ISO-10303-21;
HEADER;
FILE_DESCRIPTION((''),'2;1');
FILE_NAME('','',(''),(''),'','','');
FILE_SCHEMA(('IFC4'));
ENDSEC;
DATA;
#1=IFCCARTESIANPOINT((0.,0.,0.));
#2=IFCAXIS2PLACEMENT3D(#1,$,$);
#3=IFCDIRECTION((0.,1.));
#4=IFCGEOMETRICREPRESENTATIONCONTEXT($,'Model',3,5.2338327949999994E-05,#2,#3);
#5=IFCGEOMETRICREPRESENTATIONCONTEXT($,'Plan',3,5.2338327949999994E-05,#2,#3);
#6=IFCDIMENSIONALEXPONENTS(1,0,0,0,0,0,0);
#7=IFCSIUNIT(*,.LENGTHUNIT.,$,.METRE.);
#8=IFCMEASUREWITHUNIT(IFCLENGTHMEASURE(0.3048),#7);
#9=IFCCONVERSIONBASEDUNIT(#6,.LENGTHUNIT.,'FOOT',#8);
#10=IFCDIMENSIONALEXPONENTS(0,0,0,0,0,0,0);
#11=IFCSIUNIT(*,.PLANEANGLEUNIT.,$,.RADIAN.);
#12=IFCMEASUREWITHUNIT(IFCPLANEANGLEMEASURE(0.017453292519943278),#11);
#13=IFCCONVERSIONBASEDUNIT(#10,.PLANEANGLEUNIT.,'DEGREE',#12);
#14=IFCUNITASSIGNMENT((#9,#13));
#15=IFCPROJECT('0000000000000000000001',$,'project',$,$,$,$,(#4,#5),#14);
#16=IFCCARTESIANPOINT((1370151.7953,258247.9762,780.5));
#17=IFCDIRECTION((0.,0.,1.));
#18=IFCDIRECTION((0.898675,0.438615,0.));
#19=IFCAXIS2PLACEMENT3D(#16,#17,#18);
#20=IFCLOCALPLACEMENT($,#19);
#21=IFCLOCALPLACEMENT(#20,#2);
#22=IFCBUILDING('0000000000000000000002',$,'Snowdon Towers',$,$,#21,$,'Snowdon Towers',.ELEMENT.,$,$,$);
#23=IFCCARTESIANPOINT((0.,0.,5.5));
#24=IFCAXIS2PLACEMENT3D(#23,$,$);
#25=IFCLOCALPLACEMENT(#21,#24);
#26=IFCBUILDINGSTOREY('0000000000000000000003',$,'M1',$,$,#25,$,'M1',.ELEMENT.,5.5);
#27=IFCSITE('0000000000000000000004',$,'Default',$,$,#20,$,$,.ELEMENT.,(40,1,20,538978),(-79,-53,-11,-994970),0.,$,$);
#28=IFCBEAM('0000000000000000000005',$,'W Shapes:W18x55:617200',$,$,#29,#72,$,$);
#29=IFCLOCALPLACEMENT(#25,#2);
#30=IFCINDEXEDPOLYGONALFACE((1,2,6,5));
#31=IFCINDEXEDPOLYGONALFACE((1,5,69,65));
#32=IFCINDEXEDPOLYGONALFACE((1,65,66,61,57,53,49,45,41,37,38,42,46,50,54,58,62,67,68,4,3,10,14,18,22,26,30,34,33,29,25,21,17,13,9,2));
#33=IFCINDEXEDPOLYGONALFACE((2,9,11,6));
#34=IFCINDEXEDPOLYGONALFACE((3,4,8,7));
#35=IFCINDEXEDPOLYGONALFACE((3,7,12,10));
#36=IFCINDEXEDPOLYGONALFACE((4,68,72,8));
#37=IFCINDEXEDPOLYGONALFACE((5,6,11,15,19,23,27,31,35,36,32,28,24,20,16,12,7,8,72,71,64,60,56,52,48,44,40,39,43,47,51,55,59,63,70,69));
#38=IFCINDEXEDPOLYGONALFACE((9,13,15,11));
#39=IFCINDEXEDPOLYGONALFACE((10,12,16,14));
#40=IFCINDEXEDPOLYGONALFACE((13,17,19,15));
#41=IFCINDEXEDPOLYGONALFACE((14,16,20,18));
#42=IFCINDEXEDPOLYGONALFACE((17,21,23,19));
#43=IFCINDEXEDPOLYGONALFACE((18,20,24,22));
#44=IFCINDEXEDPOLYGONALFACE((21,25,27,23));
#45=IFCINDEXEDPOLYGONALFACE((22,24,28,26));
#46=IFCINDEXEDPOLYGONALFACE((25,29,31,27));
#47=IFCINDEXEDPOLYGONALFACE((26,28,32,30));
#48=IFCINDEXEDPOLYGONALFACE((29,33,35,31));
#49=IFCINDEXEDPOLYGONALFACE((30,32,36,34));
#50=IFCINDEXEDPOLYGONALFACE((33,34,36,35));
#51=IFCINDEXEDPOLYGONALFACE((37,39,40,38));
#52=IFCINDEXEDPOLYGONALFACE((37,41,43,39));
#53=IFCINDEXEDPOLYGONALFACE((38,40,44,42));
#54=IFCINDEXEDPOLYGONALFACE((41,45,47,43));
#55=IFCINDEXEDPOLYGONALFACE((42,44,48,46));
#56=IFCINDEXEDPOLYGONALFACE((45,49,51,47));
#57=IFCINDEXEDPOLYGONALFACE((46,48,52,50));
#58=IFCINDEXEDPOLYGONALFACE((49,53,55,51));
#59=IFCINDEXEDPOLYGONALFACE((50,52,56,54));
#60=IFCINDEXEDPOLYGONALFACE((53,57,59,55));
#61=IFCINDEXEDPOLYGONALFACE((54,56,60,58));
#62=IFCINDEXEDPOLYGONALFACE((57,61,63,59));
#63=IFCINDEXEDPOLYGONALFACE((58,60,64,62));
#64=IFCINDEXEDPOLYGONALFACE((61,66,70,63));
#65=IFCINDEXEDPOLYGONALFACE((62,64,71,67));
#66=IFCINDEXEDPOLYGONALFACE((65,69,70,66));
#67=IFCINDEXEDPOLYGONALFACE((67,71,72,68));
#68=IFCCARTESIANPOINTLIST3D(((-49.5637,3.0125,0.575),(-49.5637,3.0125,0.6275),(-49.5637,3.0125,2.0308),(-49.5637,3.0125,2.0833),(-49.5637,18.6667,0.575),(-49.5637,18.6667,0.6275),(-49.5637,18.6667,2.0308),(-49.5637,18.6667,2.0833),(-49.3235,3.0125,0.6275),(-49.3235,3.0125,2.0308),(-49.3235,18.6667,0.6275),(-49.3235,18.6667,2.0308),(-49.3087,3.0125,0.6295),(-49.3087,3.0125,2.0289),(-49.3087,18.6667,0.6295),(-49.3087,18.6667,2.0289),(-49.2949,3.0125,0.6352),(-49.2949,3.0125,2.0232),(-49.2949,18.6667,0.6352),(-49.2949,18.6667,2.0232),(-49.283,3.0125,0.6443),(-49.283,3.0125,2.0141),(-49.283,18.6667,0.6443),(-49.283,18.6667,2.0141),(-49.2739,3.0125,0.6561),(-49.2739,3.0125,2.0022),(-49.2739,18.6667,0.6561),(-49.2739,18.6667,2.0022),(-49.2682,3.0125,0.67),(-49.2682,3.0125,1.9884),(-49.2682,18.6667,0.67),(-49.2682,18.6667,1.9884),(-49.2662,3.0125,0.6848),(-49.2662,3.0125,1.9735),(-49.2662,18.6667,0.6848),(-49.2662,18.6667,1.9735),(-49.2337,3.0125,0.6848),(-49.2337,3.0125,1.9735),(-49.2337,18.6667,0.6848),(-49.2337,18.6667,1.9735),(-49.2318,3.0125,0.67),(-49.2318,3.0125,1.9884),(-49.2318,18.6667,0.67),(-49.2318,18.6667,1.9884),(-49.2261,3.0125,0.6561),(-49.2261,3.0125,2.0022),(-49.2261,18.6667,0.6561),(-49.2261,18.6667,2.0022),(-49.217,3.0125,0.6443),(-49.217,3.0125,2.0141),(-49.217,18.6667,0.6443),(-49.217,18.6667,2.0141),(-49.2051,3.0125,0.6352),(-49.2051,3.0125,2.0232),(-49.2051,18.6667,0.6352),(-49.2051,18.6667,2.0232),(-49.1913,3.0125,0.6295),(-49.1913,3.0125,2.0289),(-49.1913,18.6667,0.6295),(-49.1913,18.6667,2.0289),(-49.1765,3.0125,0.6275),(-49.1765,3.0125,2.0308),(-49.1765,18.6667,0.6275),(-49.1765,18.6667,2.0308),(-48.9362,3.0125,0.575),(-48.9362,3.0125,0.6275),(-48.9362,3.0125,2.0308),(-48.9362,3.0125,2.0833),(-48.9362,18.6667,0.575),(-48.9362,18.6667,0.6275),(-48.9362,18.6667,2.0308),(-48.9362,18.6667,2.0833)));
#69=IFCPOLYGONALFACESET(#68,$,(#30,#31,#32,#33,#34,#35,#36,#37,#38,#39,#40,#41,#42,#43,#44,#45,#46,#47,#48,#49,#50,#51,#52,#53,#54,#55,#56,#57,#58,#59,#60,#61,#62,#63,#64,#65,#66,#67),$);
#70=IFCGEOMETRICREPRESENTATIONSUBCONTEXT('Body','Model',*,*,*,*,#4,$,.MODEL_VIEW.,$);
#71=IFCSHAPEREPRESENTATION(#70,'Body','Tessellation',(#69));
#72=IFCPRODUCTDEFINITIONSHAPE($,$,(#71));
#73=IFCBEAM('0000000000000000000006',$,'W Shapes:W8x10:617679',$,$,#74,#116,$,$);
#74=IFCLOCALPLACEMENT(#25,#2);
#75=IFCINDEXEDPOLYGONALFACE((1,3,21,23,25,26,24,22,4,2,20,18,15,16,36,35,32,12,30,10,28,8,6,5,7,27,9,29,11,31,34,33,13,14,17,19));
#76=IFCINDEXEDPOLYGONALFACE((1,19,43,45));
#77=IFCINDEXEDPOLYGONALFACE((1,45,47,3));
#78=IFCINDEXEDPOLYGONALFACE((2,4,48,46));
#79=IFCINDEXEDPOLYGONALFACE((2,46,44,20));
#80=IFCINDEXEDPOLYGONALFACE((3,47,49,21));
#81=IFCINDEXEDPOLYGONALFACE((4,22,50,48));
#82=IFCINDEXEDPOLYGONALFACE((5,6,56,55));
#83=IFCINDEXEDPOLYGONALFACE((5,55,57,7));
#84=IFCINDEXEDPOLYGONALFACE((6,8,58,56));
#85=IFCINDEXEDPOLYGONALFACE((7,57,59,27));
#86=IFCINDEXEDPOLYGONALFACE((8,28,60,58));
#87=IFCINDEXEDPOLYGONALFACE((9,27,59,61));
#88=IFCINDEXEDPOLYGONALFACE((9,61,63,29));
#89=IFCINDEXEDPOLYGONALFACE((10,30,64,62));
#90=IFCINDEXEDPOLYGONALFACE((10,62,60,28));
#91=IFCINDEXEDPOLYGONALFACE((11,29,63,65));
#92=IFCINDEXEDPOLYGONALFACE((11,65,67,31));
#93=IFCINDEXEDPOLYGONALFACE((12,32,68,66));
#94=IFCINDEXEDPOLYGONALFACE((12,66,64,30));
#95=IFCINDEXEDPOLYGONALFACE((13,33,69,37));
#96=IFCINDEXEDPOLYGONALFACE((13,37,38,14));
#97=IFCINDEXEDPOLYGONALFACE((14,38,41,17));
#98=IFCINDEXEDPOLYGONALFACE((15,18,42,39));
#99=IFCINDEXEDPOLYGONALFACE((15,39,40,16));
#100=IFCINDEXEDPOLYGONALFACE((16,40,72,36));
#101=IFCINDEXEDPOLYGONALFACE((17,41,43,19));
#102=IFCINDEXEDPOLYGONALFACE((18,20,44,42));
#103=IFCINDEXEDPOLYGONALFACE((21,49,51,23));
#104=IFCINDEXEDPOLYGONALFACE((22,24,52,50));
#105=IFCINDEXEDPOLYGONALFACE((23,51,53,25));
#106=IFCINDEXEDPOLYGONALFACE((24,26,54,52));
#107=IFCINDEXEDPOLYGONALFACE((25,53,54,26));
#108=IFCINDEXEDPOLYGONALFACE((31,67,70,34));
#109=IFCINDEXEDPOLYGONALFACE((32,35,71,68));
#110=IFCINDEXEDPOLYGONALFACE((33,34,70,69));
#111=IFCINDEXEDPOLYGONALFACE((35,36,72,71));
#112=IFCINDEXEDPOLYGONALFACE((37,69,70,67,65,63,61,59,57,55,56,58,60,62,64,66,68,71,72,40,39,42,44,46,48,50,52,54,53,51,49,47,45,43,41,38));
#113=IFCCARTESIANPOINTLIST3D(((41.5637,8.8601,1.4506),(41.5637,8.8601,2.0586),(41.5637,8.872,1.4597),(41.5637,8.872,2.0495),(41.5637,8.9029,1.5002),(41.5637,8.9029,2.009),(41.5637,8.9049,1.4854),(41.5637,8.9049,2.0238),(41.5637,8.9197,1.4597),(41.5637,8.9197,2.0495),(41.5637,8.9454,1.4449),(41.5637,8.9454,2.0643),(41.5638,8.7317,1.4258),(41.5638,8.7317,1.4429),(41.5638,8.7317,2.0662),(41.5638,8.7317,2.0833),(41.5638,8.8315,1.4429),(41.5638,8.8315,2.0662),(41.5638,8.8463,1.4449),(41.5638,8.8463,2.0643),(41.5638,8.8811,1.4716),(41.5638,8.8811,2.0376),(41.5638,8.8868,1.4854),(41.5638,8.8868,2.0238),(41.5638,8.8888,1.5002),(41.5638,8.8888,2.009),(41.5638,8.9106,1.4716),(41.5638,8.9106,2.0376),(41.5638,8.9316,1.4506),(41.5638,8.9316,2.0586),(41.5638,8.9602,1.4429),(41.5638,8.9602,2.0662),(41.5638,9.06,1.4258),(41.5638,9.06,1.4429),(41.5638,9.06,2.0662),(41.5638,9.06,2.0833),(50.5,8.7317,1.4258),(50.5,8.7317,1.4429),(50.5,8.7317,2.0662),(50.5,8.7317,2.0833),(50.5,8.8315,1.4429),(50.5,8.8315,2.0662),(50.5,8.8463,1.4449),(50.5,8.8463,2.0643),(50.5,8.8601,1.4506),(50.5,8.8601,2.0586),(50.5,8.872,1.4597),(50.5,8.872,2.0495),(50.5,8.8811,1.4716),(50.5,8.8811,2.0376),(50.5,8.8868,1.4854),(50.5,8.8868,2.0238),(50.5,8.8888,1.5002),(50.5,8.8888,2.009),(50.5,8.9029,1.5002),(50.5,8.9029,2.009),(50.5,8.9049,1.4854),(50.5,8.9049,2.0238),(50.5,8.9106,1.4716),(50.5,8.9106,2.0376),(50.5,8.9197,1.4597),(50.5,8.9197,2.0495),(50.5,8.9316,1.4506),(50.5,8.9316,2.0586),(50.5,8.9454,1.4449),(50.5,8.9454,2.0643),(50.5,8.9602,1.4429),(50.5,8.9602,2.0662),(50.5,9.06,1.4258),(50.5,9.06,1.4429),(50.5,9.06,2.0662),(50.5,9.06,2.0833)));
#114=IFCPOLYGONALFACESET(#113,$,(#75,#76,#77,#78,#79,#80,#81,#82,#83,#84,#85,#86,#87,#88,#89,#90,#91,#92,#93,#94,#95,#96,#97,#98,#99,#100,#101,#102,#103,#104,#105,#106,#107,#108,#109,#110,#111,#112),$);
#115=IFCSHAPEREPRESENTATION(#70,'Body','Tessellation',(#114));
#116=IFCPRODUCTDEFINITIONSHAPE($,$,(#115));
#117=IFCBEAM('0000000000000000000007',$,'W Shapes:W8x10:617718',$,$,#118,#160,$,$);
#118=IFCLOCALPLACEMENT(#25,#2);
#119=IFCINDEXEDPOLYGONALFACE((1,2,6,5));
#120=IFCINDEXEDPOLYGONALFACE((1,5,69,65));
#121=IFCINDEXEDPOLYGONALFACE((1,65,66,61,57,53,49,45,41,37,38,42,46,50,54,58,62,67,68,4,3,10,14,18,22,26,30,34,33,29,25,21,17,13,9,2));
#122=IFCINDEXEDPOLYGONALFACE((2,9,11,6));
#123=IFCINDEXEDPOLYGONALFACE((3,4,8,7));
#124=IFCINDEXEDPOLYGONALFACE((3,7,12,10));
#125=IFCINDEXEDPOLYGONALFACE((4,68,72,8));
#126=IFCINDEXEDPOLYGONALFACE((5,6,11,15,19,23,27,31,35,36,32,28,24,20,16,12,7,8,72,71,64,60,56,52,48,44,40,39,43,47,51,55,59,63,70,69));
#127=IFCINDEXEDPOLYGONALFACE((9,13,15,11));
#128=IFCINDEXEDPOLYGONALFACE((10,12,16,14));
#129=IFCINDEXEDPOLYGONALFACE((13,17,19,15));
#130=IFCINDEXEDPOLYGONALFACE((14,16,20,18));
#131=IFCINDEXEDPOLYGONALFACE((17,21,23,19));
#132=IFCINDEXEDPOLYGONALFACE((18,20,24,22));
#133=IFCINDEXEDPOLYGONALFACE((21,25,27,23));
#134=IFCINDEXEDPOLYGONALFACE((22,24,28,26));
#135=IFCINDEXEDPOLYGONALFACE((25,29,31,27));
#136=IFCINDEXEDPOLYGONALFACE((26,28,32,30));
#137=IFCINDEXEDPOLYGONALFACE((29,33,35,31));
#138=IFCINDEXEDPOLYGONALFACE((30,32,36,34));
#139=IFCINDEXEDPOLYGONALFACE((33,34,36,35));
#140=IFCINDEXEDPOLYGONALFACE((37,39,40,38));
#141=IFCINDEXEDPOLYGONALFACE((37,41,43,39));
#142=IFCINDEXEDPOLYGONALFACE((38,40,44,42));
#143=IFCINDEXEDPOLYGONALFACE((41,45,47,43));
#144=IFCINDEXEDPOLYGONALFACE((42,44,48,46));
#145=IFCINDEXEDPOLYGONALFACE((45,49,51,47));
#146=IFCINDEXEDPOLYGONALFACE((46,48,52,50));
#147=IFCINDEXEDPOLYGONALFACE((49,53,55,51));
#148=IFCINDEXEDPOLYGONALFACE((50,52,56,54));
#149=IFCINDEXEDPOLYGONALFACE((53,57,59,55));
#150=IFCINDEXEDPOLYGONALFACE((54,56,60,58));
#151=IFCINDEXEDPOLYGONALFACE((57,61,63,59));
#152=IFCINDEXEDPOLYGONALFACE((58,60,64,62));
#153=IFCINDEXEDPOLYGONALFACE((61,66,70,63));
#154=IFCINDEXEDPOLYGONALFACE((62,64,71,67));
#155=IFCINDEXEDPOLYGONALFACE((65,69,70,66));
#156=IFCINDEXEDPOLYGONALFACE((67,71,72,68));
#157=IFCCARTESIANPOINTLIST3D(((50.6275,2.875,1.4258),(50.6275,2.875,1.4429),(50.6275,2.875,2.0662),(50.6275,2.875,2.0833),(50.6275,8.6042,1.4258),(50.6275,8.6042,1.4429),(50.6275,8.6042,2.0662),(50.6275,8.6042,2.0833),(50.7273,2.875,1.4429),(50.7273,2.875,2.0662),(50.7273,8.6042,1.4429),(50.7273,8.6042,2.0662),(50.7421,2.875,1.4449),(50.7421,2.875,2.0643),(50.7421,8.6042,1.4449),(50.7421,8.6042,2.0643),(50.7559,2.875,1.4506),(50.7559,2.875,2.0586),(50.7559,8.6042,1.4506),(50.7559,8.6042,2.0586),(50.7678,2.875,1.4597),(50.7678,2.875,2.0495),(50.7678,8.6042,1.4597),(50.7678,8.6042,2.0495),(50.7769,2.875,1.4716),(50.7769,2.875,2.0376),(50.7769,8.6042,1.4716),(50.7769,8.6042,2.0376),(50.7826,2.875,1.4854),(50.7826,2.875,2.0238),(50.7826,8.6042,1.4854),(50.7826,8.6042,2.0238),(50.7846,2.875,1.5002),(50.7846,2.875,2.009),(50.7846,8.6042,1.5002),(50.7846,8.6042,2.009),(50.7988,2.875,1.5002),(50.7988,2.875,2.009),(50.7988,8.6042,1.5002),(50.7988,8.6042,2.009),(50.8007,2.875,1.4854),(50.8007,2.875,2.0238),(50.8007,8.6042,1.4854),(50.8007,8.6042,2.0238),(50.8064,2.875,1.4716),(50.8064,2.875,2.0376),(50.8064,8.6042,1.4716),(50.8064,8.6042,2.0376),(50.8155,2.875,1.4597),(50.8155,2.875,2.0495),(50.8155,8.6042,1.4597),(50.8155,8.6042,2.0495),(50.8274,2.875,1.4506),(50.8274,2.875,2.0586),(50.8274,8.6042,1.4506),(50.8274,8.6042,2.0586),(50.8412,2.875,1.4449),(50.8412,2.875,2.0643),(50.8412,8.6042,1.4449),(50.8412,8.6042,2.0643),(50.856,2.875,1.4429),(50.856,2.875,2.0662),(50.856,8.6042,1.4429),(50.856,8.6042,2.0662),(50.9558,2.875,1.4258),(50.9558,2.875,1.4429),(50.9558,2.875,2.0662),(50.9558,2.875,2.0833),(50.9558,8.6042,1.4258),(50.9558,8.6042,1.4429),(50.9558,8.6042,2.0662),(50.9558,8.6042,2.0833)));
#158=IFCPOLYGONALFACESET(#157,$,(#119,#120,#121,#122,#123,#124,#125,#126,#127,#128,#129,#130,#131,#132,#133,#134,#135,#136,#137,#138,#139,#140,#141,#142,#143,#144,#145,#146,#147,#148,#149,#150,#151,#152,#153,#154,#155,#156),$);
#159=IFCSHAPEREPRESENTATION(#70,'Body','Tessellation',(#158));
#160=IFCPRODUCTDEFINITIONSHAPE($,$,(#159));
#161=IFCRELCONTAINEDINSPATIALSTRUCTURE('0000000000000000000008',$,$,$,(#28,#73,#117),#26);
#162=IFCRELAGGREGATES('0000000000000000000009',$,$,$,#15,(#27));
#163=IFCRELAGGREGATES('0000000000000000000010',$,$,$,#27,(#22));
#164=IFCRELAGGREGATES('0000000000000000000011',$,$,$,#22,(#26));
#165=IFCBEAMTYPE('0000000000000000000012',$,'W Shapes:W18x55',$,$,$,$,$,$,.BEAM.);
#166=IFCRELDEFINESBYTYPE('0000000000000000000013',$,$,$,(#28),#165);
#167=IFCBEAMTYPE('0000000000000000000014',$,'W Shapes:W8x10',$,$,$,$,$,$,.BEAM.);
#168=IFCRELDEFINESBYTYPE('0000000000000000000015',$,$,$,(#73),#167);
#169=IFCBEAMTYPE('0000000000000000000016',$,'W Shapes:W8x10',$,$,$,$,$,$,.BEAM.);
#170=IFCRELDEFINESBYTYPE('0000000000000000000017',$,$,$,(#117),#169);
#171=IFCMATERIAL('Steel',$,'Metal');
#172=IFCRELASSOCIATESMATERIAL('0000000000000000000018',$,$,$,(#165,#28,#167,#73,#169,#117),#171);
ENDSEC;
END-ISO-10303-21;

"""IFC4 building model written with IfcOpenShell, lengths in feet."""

from ifc_helpers import new_model, entity, si_unit, converted_unit, direction, frame, origin, place, context, subcontext, project, spatial, line, arc, indexed_curve, outline, extrude, source, transform, mapped, material, type_object, type_shapes, element, save


model = new_model("IFC4")

# Units and contexts
model_context = context("Model", 3, precision=5.2338327949999994e-05, world=origin(), true_north=direction((0.0, 1.0)))
plan_context = context("Plan", 3, precision=5.2338327949999994e-05, world=origin(), true_north=direction((0.0, 1.0)))
body_context = subcontext(model_context, "Body", "Model", "MODEL_VIEW")
ifc_project = project(units=[converted_unit("LENGTHUNIT", "FOOT", entity("IfcLengthMeasure", 0.3048), si_unit("LENGTHUNIT", "METRE"), dimensions=[1, 0, 0, 0, 0, 0, 0]), converted_unit("PLANEANGLEUNIT", "DEGREE", entity("IfcPlaneAngleMeasure", 0.017453292519943278), si_unit("PLANEANGLEUNIT", "RADIAN"), dimensions=[0, 0, 0, 0, 0, 0, 0])], contexts=[model_context, plan_context])

# Site, building, storey
site_placement = place(None, frame((1370151.7953, 258247.9762, 780.5), z_axis=(0.0, 0.0, 1.0), x_axis=(0.898675, 0.438615, 0.0)))
site = spatial("IfcSite", under=ifc_project, at=site_placement, Name="Default", CompositionType="ELEMENT", RefLatitude=(40, 1, 20, 538978), RefLongitude=(-79, -53, -11, -994970), RefElevation=0.0)
building_placement = place(site_placement, origin())
building = spatial("IfcBuilding", under=site, at=building_placement, Name="Snowdon Towers", LongName="Snowdon Towers", CompositionType="ELEMENT")
storey_placement = place(building_placement, frame((0.0, 0.0, 5.5)))
storey = spatial("IfcBuildingStorey", under=building, at=storey_placement, Name="M1", LongName="M1", CompositionType="ELEMENT", Elevation=5.5)

# Beams
ifc_material_1 = material(Name="Steel", Category="Metal")
beam_type_1 = type_object("IfcBeamType", Name="W Shapes:W18x55", PredefinedType="BEAM", material=ifc_material_1)
shared_shape_1 = source(origin(), body_context, "Body", "SweptSolid", [
    extrude(outline(indexed_curve([(-0.7542, -0.3138), (-0.7017, -0.3138), (-0.7017, -0.0735), (-0.6849, -0.033), (-0.6444, -0.0162), (0.6444, -0.0162), (0.6849, -0.033), (0.7017, -0.0735), (0.7017, -0.3138), (0.7542, -0.3138), (0.7542, 0.3138), (0.7017, 0.3138), (0.7017, 0.0735), (0.6849, 0.033), (0.6444, 0.0163), (-0.6444, 0.0163), (-0.6849, 0.033), (-0.7017, 0.0735), (-0.7017, 0.3137), (-0.7542, 0.3137)], segments=[line(1, 2, 3), arc(3, 4, 5), line(5, 6), arc(6, 7, 8), line(8, 9, 10, 11, 12, 13), arc(13, 14, 15), line(15, 16), arc(16, 17, 18), line(18, 19, 20, 1)], self_intersect=False)), frame((-7.8417, 0.0, 0.0), z_axis=(1.0, 0.0, 0.0), x_axis=(0.0, 0.0, -1.0)), (0.0, 0.0, 1.0), 15.6542),
])
type_shapes(beam_type_1, [shared_shape_1])
beam_1_placement = place(storey_placement, frame((-49.25, 10.8542, 1.3292), z_axis=(0.0, 0.0, 1.0), x_axis=(0.0, 1.0, 0.0)))
element("IfcBeam", 1, at=beam_1_placement, inside=storey, type_object=beam_type_1, material=ifc_material_1, Name="W Shapes:W18x55:617200", context=body_context, shape_type="MappedRepresentation", body=[
    mapped(shared_shape_1, transform((0.0, 0.0, 0.0), scale=1.0)),
])
beam_type_2 = type_object("IfcBeamType", Name="W Shapes:W8x10", PredefinedType="BEAM", material=ifc_material_1)
shared_shape_2 = source(origin(), body_context, "Body", "SweptSolid", [
    extrude(outline(indexed_curve([(-0.3287, -0.1642), (-0.3117, -0.1642), (-0.3117, -0.0644), (-0.2949, -0.0239), (-0.2544, -0.0071), (0.2544, -0.0071), (0.2949, -0.0239), (0.3117, -0.0644), (0.3117, -0.1642), (0.3288, -0.1642), (0.3288, 0.1642), (0.3117, 0.1642), (0.3117, 0.0644), (0.2949, 0.0239), (0.2544, 0.0071), (-0.2544, 0.0071), (-0.2949, 0.0239), (-0.3117, 0.0644), (-0.3117, 0.1642), (-0.3287, 0.1642)], segments=[line(1, 2, 3), arc(3, 4, 5), line(5, 6), arc(6, 7, 8), line(8, 9, 10, 11, 12, 13), arc(13, 14, 15), line(15, 16), arc(16, 17, 18), line(18, 19, 20, 1)], self_intersect=False)), frame((-4.4792, 0.0, 0.0), z_axis=(1.0, 0.0, 0.0), x_axis=(0.0, 0.0, -1.0)), (0.0, 0.0, 1.0), 8.9362),
])
type_shapes(beam_type_2, [shared_shape_2])
beam_2_placement = place(storey_placement, frame((46.0208, 8.8958, 1.7546), z_axis=(0.0, 0.0, 1.0), x_axis=(-1.0, 0.0, 0.0)))
element("IfcBeam", 2, at=beam_2_placement, inside=storey, type_object=beam_type_2, material=ifc_material_1, Name="W Shapes:W8x10:617679", context=body_context, shape_type="MappedRepresentation", body=[
    mapped(shared_shape_2, transform((0.0, 0.0, 0.0), scale=1.0)),
])
beam_type_3 = type_object("IfcBeamType", Name="W Shapes:W8x10", PredefinedType="BEAM", material=ifc_material_1)
shared_shape_3 = source(origin(), body_context, "Body", "SweptSolid", [
    extrude(outline(indexed_curve([(-0.3287, -0.1642), (-0.3117, -0.1642), (-0.3117, -0.0644), (-0.2949, -0.0239), (-0.2544, -0.0071), (0.2544, -0.0071), (0.2949, -0.0239), (0.3117, -0.0644), (0.3117, -0.1642), (0.3288, -0.1642), (0.3288, 0.1642), (0.3117, 0.1642), (0.3117, 0.0644), (0.2949, 0.0239), (0.2544, 0.0071), (-0.2544, 0.0071), (-0.2949, 0.0239), (-0.3117, 0.0644), (-0.3117, 0.1642), (-0.3287, 0.1642)], segments=[line(1, 2, 3), arc(3, 4, 5), line(5, 6), arc(6, 7, 8), line(8, 9, 10, 11, 12, 13), arc(13, 14, 15), line(15, 16), arc(16, 17, 18), line(18, 19, 20, 1)], self_intersect=False)), frame((-2.9167, 0.0, 0.0), z_axis=(1.0, 0.0, 0.0), x_axis=(0.0, 0.0, -1.0)), (0.0, 0.0, 1.0), 5.7292),
])
type_shapes(beam_type_3, [shared_shape_3])
beam_3_placement = place(storey_placement, frame((50.7917, 5.6875, 1.7546), z_axis=(0.0, 0.0, 1.0), x_axis=(0.0, -1.0, 0.0)))
element("IfcBeam", 3, at=beam_3_placement, inside=storey, type_object=beam_type_3, material=ifc_material_1, Name="W Shapes:W8x10:617718", context=body_context, shape_type="MappedRepresentation", body=[
    mapped(shared_shape_3, transform((0.0, 0.0, 0.0), scale=1.0)),
])

save(model, "model.ifc")
